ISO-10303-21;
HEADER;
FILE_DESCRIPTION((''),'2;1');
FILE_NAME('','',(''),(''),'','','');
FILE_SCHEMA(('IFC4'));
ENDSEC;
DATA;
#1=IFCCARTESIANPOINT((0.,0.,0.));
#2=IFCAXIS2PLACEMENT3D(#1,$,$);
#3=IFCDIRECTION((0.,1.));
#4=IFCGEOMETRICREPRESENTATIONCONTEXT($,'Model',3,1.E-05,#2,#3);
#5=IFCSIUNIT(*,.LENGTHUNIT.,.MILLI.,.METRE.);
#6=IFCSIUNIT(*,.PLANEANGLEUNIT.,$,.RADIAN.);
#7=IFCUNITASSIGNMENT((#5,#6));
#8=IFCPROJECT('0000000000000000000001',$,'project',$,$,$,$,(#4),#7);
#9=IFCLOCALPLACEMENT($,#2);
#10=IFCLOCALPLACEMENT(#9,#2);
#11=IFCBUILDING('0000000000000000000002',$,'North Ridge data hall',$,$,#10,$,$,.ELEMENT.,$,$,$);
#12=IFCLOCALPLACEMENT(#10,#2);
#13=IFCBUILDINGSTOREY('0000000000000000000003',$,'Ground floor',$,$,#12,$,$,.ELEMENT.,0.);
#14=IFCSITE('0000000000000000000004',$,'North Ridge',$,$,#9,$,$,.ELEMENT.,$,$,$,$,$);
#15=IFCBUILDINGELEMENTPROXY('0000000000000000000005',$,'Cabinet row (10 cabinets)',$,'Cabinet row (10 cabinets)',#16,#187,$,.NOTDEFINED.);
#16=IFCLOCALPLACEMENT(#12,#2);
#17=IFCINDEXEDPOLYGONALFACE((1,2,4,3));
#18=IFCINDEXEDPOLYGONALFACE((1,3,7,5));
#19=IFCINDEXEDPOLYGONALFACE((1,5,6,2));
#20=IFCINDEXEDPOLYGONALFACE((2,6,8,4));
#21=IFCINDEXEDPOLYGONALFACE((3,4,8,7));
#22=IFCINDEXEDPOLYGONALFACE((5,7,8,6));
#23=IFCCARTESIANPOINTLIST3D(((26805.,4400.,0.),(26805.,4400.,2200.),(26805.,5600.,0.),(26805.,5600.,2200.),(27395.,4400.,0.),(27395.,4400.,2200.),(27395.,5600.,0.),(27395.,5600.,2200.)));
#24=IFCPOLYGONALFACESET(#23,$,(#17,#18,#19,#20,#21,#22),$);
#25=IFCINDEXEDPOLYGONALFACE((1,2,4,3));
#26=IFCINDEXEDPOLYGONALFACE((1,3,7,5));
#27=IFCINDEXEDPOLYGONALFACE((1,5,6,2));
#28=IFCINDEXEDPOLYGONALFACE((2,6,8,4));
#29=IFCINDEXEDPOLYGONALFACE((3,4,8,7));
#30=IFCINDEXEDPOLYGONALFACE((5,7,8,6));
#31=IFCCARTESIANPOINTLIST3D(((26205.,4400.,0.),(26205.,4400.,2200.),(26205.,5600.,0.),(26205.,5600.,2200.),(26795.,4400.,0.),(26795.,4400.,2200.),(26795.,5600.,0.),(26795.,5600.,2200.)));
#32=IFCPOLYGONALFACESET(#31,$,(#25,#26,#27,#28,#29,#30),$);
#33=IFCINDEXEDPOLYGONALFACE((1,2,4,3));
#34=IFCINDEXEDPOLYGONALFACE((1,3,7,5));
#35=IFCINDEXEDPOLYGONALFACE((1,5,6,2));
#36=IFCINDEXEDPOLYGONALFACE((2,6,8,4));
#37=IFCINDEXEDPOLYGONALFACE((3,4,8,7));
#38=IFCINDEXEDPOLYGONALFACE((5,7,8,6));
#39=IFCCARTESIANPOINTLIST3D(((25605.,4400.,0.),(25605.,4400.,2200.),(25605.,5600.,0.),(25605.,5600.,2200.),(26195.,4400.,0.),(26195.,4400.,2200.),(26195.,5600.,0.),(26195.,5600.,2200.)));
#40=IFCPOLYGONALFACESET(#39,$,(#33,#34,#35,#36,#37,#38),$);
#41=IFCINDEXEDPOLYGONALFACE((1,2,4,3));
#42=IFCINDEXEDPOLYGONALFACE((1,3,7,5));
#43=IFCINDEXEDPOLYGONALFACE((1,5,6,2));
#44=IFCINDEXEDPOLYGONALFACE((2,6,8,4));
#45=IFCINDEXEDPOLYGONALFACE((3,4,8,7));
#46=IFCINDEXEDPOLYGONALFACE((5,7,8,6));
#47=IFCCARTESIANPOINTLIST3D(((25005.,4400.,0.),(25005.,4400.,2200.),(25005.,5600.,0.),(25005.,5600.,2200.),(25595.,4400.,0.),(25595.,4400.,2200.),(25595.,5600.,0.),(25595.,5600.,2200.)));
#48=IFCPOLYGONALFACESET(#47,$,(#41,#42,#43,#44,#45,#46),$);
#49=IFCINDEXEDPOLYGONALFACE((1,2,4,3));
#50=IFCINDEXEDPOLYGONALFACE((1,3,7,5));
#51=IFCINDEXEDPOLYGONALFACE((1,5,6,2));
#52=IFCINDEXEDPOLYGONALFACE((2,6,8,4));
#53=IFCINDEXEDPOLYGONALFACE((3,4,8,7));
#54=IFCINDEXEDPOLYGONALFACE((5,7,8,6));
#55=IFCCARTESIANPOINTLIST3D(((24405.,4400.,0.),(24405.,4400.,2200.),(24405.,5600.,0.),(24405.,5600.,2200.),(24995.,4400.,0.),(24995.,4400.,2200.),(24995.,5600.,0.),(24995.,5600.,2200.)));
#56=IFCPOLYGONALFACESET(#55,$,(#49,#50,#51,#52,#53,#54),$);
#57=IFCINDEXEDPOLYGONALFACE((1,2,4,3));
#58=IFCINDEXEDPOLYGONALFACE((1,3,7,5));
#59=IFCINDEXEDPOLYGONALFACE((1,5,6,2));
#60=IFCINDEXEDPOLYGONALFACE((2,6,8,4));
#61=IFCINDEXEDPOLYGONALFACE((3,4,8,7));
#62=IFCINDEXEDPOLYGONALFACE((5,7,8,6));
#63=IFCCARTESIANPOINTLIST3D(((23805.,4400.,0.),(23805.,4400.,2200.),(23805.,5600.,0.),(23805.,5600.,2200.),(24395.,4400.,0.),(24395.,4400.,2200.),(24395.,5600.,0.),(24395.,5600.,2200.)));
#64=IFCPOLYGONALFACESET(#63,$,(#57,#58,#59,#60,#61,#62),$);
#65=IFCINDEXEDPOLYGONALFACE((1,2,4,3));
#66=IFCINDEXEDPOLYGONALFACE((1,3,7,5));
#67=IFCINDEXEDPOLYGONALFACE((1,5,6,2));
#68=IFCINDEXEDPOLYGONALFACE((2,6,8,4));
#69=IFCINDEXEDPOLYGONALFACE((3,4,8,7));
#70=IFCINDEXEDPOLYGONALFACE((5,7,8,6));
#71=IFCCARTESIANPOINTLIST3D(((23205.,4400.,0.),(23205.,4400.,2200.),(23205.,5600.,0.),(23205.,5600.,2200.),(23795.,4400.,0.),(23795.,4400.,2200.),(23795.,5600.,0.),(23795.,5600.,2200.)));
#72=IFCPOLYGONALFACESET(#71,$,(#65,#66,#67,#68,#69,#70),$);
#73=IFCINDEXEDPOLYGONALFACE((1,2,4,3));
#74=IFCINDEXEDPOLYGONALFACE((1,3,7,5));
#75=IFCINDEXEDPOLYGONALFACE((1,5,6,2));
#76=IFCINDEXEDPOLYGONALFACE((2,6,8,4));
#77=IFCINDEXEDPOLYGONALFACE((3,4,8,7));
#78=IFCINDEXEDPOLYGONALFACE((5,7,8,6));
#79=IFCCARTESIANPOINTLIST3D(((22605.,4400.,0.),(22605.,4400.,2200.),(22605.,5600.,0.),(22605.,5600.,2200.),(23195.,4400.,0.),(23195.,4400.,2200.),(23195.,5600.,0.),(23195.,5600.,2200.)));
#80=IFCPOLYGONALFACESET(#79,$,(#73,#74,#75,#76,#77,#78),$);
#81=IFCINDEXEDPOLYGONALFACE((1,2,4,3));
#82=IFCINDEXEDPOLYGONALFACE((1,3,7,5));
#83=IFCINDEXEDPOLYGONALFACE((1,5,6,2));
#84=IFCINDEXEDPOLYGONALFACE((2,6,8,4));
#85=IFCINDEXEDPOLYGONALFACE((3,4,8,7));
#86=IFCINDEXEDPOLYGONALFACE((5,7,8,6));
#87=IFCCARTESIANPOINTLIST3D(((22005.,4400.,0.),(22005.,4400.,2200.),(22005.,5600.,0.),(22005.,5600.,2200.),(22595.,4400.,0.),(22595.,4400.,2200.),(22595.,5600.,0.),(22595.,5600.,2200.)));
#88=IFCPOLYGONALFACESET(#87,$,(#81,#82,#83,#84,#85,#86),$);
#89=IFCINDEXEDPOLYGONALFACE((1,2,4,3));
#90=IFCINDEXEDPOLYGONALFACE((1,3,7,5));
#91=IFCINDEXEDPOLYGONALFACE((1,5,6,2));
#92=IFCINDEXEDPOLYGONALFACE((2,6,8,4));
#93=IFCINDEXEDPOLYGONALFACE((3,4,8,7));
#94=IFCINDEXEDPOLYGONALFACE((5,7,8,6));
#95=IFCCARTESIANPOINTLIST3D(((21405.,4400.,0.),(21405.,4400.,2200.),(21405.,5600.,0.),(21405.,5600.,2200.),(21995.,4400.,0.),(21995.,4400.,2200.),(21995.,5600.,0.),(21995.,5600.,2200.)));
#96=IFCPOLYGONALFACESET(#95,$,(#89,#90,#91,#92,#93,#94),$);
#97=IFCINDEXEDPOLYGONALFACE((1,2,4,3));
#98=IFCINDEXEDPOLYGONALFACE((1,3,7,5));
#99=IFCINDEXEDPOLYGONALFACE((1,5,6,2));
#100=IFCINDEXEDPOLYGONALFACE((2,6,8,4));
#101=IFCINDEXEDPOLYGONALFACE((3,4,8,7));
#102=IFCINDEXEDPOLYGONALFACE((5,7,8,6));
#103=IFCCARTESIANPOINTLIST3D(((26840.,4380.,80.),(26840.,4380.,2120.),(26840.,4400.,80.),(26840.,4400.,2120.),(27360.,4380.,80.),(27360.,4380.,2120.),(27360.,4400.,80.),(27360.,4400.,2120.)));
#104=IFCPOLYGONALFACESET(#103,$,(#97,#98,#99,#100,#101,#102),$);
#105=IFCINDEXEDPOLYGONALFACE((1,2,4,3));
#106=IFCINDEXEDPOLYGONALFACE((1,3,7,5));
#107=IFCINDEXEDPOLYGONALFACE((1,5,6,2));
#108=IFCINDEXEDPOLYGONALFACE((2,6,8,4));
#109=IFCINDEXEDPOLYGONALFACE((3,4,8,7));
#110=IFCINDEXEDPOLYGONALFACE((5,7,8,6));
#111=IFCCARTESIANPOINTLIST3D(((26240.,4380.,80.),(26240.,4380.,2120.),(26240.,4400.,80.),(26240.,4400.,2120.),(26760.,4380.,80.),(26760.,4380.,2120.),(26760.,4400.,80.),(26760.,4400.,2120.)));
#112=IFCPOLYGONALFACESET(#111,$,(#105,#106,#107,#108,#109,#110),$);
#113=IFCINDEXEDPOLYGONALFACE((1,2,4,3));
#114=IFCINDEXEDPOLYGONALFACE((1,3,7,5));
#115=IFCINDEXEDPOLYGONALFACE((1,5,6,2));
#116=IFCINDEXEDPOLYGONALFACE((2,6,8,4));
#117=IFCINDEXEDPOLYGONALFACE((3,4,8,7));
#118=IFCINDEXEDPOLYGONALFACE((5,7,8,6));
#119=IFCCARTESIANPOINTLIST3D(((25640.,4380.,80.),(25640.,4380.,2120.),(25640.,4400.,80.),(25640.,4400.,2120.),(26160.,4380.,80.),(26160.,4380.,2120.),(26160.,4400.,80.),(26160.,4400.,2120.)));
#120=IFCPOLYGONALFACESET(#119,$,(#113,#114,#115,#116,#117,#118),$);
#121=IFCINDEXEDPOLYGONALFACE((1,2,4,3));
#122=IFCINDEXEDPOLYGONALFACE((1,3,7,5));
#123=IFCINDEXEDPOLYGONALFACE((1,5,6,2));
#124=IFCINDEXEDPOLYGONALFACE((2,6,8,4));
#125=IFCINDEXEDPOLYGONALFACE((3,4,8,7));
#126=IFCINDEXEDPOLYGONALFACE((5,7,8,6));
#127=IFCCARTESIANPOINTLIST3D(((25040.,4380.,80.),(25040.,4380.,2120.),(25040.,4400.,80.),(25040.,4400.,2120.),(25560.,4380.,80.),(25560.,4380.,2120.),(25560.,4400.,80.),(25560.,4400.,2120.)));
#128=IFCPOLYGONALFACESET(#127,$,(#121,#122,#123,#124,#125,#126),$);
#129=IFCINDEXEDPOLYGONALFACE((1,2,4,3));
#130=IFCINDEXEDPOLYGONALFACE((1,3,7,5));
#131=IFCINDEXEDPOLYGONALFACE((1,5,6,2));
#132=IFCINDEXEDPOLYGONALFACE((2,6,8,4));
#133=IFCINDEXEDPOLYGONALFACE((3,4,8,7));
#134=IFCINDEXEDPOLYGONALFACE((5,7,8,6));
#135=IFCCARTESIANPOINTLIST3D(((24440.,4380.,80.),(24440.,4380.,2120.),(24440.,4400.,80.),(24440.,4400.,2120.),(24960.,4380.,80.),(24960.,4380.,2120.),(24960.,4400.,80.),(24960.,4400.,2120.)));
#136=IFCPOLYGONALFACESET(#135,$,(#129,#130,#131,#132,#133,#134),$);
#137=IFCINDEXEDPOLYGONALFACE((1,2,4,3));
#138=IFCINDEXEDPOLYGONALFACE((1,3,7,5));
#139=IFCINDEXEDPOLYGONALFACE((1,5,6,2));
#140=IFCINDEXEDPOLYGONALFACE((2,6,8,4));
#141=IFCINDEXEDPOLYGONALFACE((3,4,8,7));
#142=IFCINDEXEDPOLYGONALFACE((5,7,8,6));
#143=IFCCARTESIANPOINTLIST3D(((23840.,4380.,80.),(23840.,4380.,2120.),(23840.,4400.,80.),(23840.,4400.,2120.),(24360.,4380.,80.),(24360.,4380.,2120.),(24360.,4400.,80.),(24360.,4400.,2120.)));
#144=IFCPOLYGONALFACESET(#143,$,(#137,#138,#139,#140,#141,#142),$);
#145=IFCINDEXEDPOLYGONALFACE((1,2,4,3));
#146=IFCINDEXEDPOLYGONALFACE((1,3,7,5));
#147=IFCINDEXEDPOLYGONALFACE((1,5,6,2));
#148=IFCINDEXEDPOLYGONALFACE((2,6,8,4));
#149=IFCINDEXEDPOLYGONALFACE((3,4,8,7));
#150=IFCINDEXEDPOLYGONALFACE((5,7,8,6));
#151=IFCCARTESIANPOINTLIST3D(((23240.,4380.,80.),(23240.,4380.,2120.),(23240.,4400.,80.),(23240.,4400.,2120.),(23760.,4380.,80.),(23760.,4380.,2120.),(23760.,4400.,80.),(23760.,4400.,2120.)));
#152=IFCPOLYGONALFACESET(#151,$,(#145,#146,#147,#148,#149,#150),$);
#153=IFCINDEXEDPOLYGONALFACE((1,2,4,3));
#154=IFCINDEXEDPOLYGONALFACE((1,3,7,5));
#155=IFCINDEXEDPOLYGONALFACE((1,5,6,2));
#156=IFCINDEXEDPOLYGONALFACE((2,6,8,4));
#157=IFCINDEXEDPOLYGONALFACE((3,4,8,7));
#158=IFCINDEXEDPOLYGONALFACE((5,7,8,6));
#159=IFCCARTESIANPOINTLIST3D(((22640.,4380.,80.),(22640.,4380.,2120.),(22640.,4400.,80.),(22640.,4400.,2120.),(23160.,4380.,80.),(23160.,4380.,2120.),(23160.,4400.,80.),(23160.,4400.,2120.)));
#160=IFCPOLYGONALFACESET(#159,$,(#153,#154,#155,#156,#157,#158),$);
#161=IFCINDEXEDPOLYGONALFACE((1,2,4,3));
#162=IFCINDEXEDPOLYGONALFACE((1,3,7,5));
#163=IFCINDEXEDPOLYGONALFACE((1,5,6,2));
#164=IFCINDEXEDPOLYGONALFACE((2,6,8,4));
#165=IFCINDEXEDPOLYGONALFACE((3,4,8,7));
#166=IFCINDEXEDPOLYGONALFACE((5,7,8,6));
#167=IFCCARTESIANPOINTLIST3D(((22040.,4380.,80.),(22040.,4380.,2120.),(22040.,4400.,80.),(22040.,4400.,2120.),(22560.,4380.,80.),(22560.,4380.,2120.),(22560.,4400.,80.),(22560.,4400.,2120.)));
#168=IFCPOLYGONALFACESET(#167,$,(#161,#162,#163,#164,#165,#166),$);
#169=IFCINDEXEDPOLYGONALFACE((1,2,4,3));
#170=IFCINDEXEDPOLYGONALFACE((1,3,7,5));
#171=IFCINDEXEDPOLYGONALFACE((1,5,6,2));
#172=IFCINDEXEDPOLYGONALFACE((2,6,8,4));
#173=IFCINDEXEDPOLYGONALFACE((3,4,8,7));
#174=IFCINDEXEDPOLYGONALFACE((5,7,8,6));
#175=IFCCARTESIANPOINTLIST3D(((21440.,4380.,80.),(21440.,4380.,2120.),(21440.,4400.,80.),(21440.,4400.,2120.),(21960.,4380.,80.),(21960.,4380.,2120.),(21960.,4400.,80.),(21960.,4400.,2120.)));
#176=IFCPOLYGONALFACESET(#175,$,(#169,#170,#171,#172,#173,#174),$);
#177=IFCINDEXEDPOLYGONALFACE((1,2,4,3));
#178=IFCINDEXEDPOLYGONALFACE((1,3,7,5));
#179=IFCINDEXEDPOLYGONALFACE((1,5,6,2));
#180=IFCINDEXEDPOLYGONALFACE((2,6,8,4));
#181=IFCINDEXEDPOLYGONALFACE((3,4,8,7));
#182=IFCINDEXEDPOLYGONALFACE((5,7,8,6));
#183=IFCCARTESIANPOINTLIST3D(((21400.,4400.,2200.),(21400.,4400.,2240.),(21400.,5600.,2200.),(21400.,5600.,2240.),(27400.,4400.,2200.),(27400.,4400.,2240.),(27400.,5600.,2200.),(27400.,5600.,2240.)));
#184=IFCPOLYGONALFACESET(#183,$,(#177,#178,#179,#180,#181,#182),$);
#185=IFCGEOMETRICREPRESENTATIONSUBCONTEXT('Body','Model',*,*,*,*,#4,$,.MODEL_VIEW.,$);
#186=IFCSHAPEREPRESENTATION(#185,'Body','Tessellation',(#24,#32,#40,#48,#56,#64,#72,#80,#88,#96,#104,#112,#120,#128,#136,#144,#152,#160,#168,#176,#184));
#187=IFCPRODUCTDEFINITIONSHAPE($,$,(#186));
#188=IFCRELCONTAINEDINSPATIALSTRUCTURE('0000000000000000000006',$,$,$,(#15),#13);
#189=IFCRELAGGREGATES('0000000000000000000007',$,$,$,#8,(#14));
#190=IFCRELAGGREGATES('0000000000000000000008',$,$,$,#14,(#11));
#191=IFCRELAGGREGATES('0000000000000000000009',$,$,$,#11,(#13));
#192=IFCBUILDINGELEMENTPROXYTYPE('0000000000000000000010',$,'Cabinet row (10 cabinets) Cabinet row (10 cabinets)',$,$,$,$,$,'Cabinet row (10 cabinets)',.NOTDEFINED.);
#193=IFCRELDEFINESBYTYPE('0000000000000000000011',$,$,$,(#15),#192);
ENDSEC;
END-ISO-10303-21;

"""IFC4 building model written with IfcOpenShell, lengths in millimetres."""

from ifc_helpers import new_model, si_unit, direction, frame, origin, place, context, subcontext, project, spatial, polyline, outline, extrude, source, transform, mapped, type_object, type_shapes, element, save


model = new_model("IFC4")

# Units and contexts
model_context = context("Model", 3, precision=1e-05, world=origin(), true_north=direction((0.0, 1.0)))
body_context = subcontext(model_context, "Body", "Model", "MODEL_VIEW")
ifc_project = project(units=[si_unit("LENGTHUNIT", "METRE", prefix="MILLI"), si_unit("PLANEANGLEUNIT", "RADIAN")], contexts=[model_context])

# Site, building, storey
site_placement = place(None, origin())
site = spatial("IfcSite", under=ifc_project, at=site_placement, Name="North Ridge", CompositionType="ELEMENT")
building_placement = place(site_placement, origin())
building = spatial("IfcBuilding", under=site, at=building_placement, Name="North Ridge data hall", CompositionType="ELEMENT")
storey_placement = place(building_placement, origin())
storey = spatial("IfcBuildingStorey", under=building, at=storey_placement, Name="Ground floor", CompositionType="ELEMENT", Elevation=0.0)

# Building element proxy
building_element_proxy_type_1 = type_object("IfcBuildingElementProxyType", Name="Cabinet row (10 cabinets) Cabinet row (10 cabinets)", ElementType="Cabinet row (10 cabinets)", PredefinedType="NOTDEFINED")
shared_shape_1 = source(origin(), body_context, "Body", "SweptSolid", [
    extrude(outline(polyline([(5.0, 0.0), (595.0, 0.0), (595.0, 1200.0), (5.0, 1200.0), (5.0, 0.0)])), origin(), (0.0, 0.0, 1.0), 2200.0),
    extrude(outline(polyline([(605.0, 0.0), (1195.0, 0.0), (1195.0, 1200.0), (605.0, 1200.0), (605.0, 0.0)])), origin(), (0.0, 0.0, 1.0), 2200.0),
    extrude(outline(polyline([(1205.0, 0.0), (1795.0, 0.0), (1795.0, 1200.0), (1205.0, 1200.0), (1205.0, 0.0)])), origin(), (0.0, 0.0, 1.0), 2200.0),
    extrude(outline(polyline([(1805.0, 0.0), (2395.0, 0.0), (2395.0, 1200.0), (1805.0, 1200.0), (1805.0, 0.0)])), origin(), (0.0, 0.0, 1.0), 2200.0),
    extrude(outline(polyline([(2405.0, 0.0), (2995.0, 0.0), (2995.0, 1200.0), (2405.0, 1200.0), (2405.0, 0.0)])), origin(), (0.0, 0.0, 1.0), 2200.0),
    extrude(outline(polyline([(3005.0, 0.0), (3595.0, 0.0), (3595.0, 1200.0), (3005.0, 1200.0), (3005.0, 0.0)])), origin(), (0.0, 0.0, 1.0), 2200.0),
    extrude(outline(polyline([(3605.0, 0.0), (4195.0, 0.0), (4195.0, 1200.0), (3605.0, 1200.0), (3605.0, 0.0)])), origin(), (0.0, 0.0, 1.0), 2200.0),
    extrude(outline(polyline([(4205.0, 0.0), (4795.0, 0.0), (4795.0, 1200.0), (4205.0, 1200.0), (4205.0, 0.0)])), origin(), (0.0, 0.0, 1.0), 2200.0),
    extrude(outline(polyline([(4805.0, 0.0), (5395.0, 0.0), (5395.0, 1200.0), (4805.0, 1200.0), (4805.0, 0.0)])), origin(), (0.0, 0.0, 1.0), 2200.0),
    extrude(outline(polyline([(5405.0, 0.0), (5995.0, 0.0), (5995.0, 1200.0), (5405.0, 1200.0), (5405.0, 0.0)])), origin(), (0.0, 0.0, 1.0), 2200.0),
    extrude(outline(polyline([(40.0, 1200.0), (560.0, 1200.0), (560.0, 1220.0), (40.0, 1220.0), (40.0, 1200.0)])), frame((0.0, 0.0, 80.0)), (0.0, 0.0, 1.0), 2040.0),
    extrude(outline(polyline([(640.0, 1200.0), (1160.0, 1200.0), (1160.0, 1220.0), (640.0, 1220.0), (640.0, 1200.0)])), frame((0.0, 0.0, 80.0)), (0.0, 0.0, 1.0), 2040.0),
    extrude(outline(polyline([(1240.0, 1200.0), (1760.0, 1200.0), (1760.0, 1220.0), (1240.0, 1220.0), (1240.0, 1200.0)])), frame((0.0, 0.0, 80.0)), (0.0, 0.0, 1.0), 2040.0),
    extrude(outline(polyline([(1840.0, 1200.0), (2360.0, 1200.0), (2360.0, 1220.0), (1840.0, 1220.0), (1840.0, 1200.0)])), frame((0.0, 0.0, 80.0)), (0.0, 0.0, 1.0), 2040.0),
    extrude(outline(polyline([(2440.0, 1200.0), (2960.0, 1200.0), (2960.0, 1220.0), (2440.0, 1220.0), (2440.0, 1200.0)])), frame((0.0, 0.0, 80.0)), (0.0, 0.0, 1.0), 2040.0),
    extrude(outline(polyline([(3040.0, 1200.0), (3560.0, 1200.0), (3560.0, 1220.0), (3040.0, 1220.0), (3040.0, 1200.0)])), frame((0.0, 0.0, 80.0)), (0.0, 0.0, 1.0), 2040.0),
    extrude(outline(polyline([(3640.0, 1200.0), (4160.0, 1200.0), (4160.0, 1220.0), (3640.0, 1220.0), (3640.0, 1200.0)])), frame((0.0, 0.0, 80.0)), (0.0, 0.0, 1.0), 2040.0),
    extrude(outline(polyline([(4240.0, 1200.0), (4760.0, 1200.0), (4760.0, 1220.0), (4240.0, 1220.0), (4240.0, 1200.0)])), frame((0.0, 0.0, 80.0)), (0.0, 0.0, 1.0), 2040.0),
    extrude(outline(polyline([(4840.0, 1200.0), (5360.0, 1200.0), (5360.0, 1220.0), (4840.0, 1220.0), (4840.0, 1200.0)])), frame((0.0, 0.0, 80.0)), (0.0, 0.0, 1.0), 2040.0),
    extrude(outline(polyline([(5440.0, 1200.0), (5960.0, 1200.0), (5960.0, 1220.0), (5440.0, 1220.0), (5440.0, 1200.0)])), frame((0.0, 0.0, 80.0)), (0.0, 0.0, 1.0), 2040.0),
    extrude(outline(polyline([(0.0, 0.0), (6000.0, 0.0), (6000.0, 1200.0), (0.0, 1200.0), (0.0, 0.0)])), frame((0.0, 0.0, 2200.0)), (0.0, 0.0, 1.0), 40.0),
])
type_shapes(building_element_proxy_type_1, [shared_shape_1])
for number, where, z_axis, x_axis, name in (
    (1, (27400.0, 5600.0, 0.0), (0.0, 0.0, 1.0), (-1.0, 0.0, 0.0), "Cabinet row (10 cabinets)"),
):
    element("IfcBuildingElementProxy", number, at=place(storey_placement, frame(where, z_axis=z_axis, x_axis=x_axis)), inside=storey, type_object=building_element_proxy_type_1, Name=name, ObjectType="Cabinet row (10 cabinets)", PredefinedType="NOTDEFINED", context=body_context, shape_type="MappedRepresentation", body=[
        mapped(shared_shape_1, transform((0.0, 0.0, 0.0))),
    ])

save(model, "model.ifc")
